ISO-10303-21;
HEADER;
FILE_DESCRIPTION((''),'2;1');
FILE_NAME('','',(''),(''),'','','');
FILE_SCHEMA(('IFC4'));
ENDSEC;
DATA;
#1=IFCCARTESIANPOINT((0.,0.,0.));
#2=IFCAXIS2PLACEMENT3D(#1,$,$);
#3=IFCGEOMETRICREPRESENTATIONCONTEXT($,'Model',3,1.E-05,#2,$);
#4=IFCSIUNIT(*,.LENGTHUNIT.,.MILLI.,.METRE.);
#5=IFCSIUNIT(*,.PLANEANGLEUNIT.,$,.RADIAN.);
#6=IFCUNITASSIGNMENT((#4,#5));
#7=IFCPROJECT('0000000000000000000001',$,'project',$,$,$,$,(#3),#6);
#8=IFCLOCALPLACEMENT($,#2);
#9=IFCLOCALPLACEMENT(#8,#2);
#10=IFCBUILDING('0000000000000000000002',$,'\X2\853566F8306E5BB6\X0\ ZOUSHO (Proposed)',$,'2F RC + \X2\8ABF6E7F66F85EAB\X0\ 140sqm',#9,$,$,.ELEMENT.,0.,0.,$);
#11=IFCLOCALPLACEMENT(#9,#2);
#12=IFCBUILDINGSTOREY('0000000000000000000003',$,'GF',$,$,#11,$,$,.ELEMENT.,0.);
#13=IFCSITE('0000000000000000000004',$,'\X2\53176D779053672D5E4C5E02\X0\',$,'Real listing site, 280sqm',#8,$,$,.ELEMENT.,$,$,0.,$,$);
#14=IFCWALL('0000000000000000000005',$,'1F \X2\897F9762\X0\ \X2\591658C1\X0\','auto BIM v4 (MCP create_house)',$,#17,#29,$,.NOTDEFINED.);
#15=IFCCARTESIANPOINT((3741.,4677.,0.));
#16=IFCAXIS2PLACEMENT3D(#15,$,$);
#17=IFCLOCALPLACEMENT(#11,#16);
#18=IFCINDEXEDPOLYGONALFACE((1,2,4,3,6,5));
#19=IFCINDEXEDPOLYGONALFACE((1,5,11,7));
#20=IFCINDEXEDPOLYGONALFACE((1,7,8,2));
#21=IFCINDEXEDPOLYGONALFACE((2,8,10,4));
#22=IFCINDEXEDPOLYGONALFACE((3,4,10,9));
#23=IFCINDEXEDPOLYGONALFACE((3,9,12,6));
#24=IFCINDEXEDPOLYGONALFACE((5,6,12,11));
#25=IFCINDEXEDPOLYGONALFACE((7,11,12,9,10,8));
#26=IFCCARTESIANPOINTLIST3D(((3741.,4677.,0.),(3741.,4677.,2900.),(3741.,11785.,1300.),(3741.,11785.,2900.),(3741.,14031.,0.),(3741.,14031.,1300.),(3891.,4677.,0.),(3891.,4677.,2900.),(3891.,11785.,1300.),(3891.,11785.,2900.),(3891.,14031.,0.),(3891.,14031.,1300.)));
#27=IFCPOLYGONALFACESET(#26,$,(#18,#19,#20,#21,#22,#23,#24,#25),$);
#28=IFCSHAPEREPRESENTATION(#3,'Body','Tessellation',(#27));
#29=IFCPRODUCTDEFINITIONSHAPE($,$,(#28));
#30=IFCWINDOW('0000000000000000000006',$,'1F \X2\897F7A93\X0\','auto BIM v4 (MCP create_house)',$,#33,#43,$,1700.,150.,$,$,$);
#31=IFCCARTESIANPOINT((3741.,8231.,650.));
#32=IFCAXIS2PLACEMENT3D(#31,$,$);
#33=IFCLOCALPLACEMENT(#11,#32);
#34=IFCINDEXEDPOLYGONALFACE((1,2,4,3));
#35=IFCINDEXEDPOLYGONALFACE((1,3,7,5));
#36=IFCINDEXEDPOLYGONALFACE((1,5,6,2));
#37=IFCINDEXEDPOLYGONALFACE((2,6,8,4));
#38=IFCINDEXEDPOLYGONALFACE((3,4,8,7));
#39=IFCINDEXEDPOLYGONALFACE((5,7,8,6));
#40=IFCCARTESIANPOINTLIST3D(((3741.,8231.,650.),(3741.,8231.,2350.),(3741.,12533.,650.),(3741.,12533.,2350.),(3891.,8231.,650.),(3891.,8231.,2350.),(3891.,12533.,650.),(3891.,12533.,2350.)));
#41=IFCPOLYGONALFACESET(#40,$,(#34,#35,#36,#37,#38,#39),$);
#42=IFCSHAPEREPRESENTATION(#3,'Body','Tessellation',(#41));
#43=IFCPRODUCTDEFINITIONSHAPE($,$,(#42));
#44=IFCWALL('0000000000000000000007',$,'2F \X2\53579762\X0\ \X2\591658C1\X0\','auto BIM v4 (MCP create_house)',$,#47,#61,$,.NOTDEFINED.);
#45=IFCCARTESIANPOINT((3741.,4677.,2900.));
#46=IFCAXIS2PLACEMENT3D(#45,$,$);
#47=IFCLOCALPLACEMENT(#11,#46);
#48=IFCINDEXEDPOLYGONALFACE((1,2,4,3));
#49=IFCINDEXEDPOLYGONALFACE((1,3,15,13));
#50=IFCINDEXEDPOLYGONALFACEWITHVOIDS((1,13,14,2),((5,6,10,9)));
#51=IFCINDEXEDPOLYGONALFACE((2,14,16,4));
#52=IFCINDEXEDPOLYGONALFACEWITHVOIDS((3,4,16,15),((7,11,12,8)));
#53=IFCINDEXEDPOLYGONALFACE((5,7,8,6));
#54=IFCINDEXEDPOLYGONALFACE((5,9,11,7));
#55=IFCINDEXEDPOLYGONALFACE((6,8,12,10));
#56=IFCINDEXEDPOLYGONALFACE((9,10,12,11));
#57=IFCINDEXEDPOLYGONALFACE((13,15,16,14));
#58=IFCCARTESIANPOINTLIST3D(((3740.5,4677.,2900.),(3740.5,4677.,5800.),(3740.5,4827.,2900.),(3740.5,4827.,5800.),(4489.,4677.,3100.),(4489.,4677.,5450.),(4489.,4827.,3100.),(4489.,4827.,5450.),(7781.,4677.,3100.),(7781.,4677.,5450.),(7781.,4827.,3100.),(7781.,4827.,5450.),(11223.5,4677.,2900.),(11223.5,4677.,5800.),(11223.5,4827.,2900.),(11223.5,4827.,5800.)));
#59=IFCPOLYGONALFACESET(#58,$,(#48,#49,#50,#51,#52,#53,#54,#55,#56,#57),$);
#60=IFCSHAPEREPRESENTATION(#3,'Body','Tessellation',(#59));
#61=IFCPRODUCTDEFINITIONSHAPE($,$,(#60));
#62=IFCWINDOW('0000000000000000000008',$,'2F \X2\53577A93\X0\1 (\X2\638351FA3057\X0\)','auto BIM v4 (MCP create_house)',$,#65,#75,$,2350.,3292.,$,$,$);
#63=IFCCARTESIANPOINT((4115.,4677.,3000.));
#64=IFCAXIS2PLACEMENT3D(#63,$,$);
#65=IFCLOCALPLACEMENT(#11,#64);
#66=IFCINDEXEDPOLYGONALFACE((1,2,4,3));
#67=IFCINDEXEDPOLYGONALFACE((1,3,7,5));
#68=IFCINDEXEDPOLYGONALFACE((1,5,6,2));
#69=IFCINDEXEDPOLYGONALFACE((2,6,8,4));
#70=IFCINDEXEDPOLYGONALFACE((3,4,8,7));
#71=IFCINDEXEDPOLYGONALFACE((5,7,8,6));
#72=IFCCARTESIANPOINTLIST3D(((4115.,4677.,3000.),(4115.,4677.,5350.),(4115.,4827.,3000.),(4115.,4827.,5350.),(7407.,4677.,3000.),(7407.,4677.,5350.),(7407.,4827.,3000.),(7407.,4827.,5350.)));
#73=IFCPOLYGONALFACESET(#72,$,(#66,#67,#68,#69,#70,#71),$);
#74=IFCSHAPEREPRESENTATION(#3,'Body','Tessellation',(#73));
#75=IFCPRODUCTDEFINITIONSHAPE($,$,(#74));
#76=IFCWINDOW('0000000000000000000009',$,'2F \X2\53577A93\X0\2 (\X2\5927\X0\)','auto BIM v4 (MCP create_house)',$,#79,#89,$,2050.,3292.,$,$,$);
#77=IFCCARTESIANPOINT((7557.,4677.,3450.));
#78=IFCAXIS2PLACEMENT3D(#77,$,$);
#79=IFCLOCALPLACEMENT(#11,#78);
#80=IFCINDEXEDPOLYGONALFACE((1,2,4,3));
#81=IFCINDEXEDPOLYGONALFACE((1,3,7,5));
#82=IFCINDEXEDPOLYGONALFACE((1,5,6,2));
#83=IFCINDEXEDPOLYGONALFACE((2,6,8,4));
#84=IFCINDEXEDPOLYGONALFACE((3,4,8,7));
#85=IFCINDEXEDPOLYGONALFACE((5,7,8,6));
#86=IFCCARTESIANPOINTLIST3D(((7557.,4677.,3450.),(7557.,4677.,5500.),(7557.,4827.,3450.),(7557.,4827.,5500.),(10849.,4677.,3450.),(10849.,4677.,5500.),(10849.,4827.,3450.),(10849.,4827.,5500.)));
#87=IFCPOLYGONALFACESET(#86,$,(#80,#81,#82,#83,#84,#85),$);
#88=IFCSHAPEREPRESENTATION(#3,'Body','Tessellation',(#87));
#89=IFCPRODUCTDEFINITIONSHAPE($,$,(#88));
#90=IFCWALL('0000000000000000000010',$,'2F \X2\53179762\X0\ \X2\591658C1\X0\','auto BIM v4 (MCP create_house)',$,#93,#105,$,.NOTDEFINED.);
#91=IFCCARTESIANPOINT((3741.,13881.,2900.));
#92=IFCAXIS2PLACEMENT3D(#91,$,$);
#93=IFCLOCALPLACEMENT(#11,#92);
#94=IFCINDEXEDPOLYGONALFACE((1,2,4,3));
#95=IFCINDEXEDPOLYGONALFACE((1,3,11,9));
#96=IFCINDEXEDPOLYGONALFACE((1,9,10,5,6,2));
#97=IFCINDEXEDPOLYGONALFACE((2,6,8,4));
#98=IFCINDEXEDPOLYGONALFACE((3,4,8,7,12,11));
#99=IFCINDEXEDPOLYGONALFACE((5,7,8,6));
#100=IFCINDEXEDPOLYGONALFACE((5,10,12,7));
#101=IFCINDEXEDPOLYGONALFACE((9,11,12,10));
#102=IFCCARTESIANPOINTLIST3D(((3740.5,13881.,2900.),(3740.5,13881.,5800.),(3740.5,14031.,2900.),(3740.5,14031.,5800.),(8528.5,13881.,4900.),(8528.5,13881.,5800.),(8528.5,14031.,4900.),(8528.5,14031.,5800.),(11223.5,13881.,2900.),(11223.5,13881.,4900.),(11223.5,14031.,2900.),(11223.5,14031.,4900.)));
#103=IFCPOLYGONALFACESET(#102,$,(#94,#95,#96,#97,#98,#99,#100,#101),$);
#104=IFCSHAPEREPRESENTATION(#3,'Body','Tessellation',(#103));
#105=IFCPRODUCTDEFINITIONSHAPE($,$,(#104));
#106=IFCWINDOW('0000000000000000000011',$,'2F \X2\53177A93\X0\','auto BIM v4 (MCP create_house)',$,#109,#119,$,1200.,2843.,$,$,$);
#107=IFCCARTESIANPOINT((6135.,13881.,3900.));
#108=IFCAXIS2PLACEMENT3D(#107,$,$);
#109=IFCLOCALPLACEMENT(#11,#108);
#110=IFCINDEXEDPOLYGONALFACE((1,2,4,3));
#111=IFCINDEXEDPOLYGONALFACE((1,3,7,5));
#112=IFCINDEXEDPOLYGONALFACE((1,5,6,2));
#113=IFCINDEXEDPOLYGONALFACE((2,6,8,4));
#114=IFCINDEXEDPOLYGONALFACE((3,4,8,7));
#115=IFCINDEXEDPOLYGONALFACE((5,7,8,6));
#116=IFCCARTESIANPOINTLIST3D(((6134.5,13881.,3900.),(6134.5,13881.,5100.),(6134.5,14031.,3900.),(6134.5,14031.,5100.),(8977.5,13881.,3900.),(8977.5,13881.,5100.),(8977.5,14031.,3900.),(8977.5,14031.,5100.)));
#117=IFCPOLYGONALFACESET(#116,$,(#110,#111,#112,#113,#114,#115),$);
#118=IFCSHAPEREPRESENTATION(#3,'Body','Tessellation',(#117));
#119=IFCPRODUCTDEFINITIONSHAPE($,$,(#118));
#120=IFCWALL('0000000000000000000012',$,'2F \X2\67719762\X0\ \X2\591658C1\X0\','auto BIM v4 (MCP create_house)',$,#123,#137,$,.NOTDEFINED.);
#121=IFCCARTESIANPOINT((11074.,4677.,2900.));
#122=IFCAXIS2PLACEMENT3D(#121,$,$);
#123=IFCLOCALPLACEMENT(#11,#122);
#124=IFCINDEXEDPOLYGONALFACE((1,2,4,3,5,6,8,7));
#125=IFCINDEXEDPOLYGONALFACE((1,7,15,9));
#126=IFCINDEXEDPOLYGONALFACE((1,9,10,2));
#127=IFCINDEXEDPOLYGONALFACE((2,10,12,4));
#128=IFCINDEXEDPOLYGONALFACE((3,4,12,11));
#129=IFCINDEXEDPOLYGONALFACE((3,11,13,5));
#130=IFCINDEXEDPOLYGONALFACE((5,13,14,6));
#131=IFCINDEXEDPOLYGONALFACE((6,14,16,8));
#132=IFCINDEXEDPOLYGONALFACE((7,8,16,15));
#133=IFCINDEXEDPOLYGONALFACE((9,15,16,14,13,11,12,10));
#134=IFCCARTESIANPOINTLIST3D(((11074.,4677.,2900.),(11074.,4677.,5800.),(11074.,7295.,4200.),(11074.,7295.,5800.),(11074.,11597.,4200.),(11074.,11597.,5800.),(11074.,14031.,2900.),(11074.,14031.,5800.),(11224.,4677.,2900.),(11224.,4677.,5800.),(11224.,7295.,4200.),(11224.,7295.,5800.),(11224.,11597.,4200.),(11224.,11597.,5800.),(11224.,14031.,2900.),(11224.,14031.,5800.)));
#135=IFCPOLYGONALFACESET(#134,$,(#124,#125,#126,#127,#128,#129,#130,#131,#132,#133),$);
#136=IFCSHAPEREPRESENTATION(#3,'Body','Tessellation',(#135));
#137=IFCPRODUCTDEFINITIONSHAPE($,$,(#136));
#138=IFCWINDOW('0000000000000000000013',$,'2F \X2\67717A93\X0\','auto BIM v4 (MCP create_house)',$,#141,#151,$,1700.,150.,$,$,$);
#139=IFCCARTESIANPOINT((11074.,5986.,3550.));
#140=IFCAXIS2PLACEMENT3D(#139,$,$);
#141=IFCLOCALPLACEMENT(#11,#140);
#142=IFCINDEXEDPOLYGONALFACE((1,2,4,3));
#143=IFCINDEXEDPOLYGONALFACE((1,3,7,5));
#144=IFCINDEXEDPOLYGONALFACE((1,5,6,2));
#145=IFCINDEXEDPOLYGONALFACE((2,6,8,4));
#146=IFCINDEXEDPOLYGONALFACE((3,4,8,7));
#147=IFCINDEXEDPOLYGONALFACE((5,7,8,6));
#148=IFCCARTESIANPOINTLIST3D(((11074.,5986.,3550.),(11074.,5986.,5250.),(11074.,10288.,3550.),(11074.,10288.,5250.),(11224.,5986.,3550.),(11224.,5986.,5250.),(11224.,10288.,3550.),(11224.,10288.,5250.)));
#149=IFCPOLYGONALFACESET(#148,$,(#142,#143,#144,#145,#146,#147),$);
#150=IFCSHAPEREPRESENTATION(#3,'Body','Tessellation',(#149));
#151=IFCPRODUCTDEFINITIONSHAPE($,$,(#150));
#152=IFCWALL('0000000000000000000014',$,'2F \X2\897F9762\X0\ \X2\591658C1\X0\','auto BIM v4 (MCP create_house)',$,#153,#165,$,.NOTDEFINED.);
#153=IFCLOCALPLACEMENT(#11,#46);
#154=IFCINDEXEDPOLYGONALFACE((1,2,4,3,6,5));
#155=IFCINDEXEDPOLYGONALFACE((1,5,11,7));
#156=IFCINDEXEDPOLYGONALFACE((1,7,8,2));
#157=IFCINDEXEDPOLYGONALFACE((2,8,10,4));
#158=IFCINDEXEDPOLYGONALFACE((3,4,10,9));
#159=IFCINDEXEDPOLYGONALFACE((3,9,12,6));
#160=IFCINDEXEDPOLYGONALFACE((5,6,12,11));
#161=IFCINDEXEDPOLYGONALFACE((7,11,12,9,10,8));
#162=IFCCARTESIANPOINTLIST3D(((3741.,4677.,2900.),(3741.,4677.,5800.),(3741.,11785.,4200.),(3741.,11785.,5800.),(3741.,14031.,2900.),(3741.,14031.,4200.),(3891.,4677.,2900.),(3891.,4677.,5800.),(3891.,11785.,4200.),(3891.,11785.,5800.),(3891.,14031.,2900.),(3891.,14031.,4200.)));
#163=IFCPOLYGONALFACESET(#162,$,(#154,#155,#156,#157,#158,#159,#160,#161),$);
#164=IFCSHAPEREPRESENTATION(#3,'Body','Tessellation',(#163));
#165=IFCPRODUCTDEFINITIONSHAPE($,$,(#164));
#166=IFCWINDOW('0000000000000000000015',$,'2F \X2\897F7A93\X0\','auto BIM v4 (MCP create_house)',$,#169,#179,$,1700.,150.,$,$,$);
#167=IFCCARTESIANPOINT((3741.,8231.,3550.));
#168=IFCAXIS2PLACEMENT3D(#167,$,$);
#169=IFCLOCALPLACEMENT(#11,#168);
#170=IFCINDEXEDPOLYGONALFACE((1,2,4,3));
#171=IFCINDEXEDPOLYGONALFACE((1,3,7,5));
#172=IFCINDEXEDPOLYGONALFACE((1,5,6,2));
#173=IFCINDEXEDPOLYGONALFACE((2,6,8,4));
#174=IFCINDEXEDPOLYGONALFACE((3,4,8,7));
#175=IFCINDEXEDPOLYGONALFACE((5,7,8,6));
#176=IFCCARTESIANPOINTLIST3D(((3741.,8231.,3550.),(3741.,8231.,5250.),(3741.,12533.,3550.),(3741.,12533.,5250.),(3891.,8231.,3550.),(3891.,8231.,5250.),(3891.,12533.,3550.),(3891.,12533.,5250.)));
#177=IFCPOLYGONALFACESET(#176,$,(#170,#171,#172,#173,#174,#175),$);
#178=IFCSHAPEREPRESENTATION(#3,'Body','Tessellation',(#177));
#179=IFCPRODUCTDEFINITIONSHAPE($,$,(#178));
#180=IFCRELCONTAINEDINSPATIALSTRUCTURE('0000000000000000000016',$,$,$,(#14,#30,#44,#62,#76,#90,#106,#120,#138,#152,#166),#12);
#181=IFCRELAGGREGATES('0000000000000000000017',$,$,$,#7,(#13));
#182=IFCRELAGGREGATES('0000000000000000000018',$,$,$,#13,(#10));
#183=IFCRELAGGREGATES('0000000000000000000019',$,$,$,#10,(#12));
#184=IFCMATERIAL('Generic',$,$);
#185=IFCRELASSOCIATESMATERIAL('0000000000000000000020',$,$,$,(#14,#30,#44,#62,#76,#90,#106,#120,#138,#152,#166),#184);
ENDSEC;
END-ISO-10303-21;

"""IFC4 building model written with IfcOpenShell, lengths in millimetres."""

from ifc_helpers import new_model, si_unit, frame, frame_2d, origin, place, context, project, spatial, rectangle, extrude, material, element, fill, save


model = new_model("IFC4")

# Units and contexts
model_context = context("Model", 3, precision=1e-05, world=origin())
ifc_project = project(units=[si_unit("LENGTHUNIT", "METRE", prefix="MILLI"), si_unit("PLANEANGLEUNIT", "RADIAN")], contexts=[model_context])

# Site, building, storey
site_placement = place(None, origin())
site = spatial("IfcSite", under=ifc_project, at=site_placement, Name="北海道札幌市", ObjectType="Real listing site, 280sqm", CompositionType="ELEMENT", RefElevation=0.0)
building_placement = place(site_placement, origin())
building = spatial("IfcBuilding", under=site, at=building_placement, Name="蔵書の家 ZOUSHO (Proposed)", ObjectType="2F RC + 調湿書庫 140sqm", CompositionType="ELEMENT", ElevationOfRefHeight=0.0, ElevationOfTerrain=0.0)
storey_placement = place(building_placement, origin())
storey = spatial("IfcBuildingStorey", under=building, at=storey_placement, Name="GF", CompositionType="ELEMENT", Elevation=0.0)

# Shared definitions
ifc_material = material(Name="Generic")

# Wall, opening, window
wall_1_placement = place(storey_placement, frame((3741.0, 4677.0, 0.0)))
wall_1 = element("IfcWall", 1, at=wall_1_placement, inside=storey, material=ifc_material, Name="1F 西面 外壁", Description="auto BIM v4 (MCP create_house)", PredefinedType="NOTDEFINED", context=model_context, shape_type="SweptSolid", body=[
    extrude(rectangle(XDim=150.0, YDim=9354.0, at=frame_2d((75.0, 4677.0))), frame((3741.0, 4677.0, 0.0)), (0.0, 0.0, 1.0), 2900.0),
])
opening_1_placement = place(storey_placement, frame((3741.0, 8231.0, 650.0)))
opening_1 = element("IfcOpeningElement", 2, at=opening_1_placement, cuts=wall_1, PredefinedType="NOTDEFINED", context=model_context, shape_type="SweptSolid", body=[
    extrude(rectangle(XDim=150.0, YDim=4302.0, at=frame_2d((75.0, 2151.0))), frame((3741.0, 8231.0, 650.0)), (0.0, 0.0, 1.0), 1700.0),
])
window_1_placement = place(storey_placement, frame((3741.0, 8231.0, 650.0)))
window_1 = element("IfcWindow", 3, at=window_1_placement, inside=storey, material=ifc_material, Name="1F 西窓", Description="auto BIM v4 (MCP create_house)", OverallHeight=1700.0, OverallWidth=150.0, context=model_context, shape_type="SweptSolid", body=[
    extrude(rectangle(XDim=150.0, YDim=4302.0, at=frame_2d((75.0, 2151.0))), frame((3741.0, 8231.0, 650.0)), (0.0, 0.0, 1.0), 1700.0),
])
fill(opening_1, window_1)

# Wall, openings, windows
wall_2_placement = place(storey_placement, frame((3741.0, 4677.0, 2900.0)))
wall_2 = element("IfcWall", 4, at=wall_2_placement, inside=storey, material=ifc_material, Name="2F 南面 外壁", Description="auto BIM v4 (MCP create_house)", PredefinedType="NOTDEFINED", context=model_context, shape_type="SweptSolid", body=[
    extrude(rectangle(XDim=7483.0, YDim=150.0, at=frame_2d((3741.0, 75.0))), frame((3741.0, 4677.0, 2900.0)), (0.0, 0.0, 1.0), 2900.0),
])
opening_2_placement = place(storey_placement, frame((4115.0, 4677.0, 3000.0)))
opening_2 = element("IfcOpeningElement", 5, at=opening_2_placement, cuts=wall_2, PredefinedType="NOTDEFINED", context=model_context, shape_type="SweptSolid", body=[
    extrude(rectangle(XDim=3292.0, YDim=150.0, at=frame_2d((1646.0, 75.0))), frame((4115.0, 4677.0, 3000.0)), (0.0, 0.0, 1.0), 2350.0),
])
opening_3_placement = place(storey_placement, frame((7557.0, 4677.0, 3450.0)))
opening_3 = element("IfcOpeningElement", 6, at=opening_3_placement, cuts=wall_2, PredefinedType="NOTDEFINED", context=model_context, shape_type="SweptSolid", body=[
    extrude(rectangle(XDim=3292.0, YDim=150.0, at=frame_2d((1646.0, 75.0))), frame((7557.0, 4677.0, 3450.0)), (0.0, 0.0, 1.0), 2050.0),
])
window_2_placement = place(storey_placement, frame((4115.0, 4677.0, 3000.0)))
window_2 = element("IfcWindow", 7, at=window_2_placement, inside=storey, material=ifc_material, Name="2F 南窓1 (掃出し)", Description="auto BIM v4 (MCP create_house)", OverallHeight=2350.0, OverallWidth=3292.0, context=model_context, shape_type="SweptSolid", body=[
    extrude(rectangle(XDim=3292.0, YDim=150.0, at=frame_2d((1646.0, 75.0))), frame((4115.0, 4677.0, 3000.0)), (0.0, 0.0, 1.0), 2350.0),
])
fill(opening_2, window_2)
window_3_placement = place(storey_placement, frame((7557.0, 4677.0, 3450.0)))
window_3 = element("IfcWindow", 8, at=window_3_placement, inside=storey, material=ifc_material, Name="2F 南窓2 (大)", Description="auto BIM v4 (MCP create_house)", OverallHeight=2050.0, OverallWidth=3292.0, context=model_context, shape_type="SweptSolid", body=[
    extrude(rectangle(XDim=3292.0, YDim=150.0, at=frame_2d((1646.0, 75.0))), frame((7557.0, 4677.0, 3450.0)), (0.0, 0.0, 1.0), 2050.0),
])
fill(opening_3, window_3)

# Walls, openings, windows
wall_3_placement = place(storey_placement, frame((3741.0, 13881.0, 2900.0)))
wall_3 = element("IfcWall", 9, at=wall_3_placement, inside=storey, material=ifc_material, Name="2F 北面 外壁", Description="auto BIM v4 (MCP create_house)", PredefinedType="NOTDEFINED", context=model_context, shape_type="SweptSolid", body=[
    extrude(rectangle(XDim=7483.0, YDim=150.0, at=frame_2d((3741.0, 75.0))), frame((3741.0, 13881.0, 2900.0)), (0.0, 0.0, 1.0), 2900.0),
])
opening_4_placement = place(storey_placement, frame((6135.0, 13881.0, 3900.0)))
opening_4 = element("IfcOpeningElement", 10, at=opening_4_placement, cuts=wall_3, PredefinedType="NOTDEFINED", context=model_context, shape_type="SweptSolid", body=[
    extrude(rectangle(XDim=2843.0, YDim=150.0, at=frame_2d((1421.0, 75.0))), frame((6135.0, 13881.0, 3900.0)), (0.0, 0.0, 1.0), 1200.0),
])
window_4_placement = place(storey_placement, frame((6135.0, 13881.0, 3900.0)))
window_4 = element("IfcWindow", 11, at=window_4_placement, inside=storey, material=ifc_material, Name="2F 北窓", Description="auto BIM v4 (MCP create_house)", OverallHeight=1200.0, OverallWidth=2843.0, context=model_context, shape_type="SweptSolid", body=[
    extrude(rectangle(XDim=2843.0, YDim=150.0, at=frame_2d((1421.0, 75.0))), frame((6135.0, 13881.0, 3900.0)), (0.0, 0.0, 1.0), 1200.0),
])
fill(opening_4, window_4)
wall_4_placement = place(storey_placement, frame((11074.0, 4677.0, 2900.0)))
wall_4 = element("IfcWall", 12, at=wall_4_placement, inside=storey, material=ifc_material, Name="2F 東面 外壁", Description="auto BIM v4 (MCP create_house)", PredefinedType="NOTDEFINED", context=model_context, shape_type="SweptSolid", body=[
    extrude(rectangle(XDim=150.0, YDim=9354.0, at=frame_2d((75.0, 4677.0))), frame((11074.0, 4677.0, 2900.0)), (0.0, 0.0, 1.0), 2900.0),
])
opening_5_placement = place(storey_placement, frame((11074.0, 5986.0, 3550.0)))
opening_5 = element("IfcOpeningElement", 13, at=opening_5_placement, cuts=wall_4, PredefinedType="NOTDEFINED", context=model_context, shape_type="SweptSolid", body=[
    extrude(rectangle(XDim=150.0, YDim=4302.0, at=frame_2d((75.0, 2151.0))), frame((11074.0, 5986.0, 3550.0)), (0.0, 0.0, 1.0), 1700.0),
])
window_5_placement = place(storey_placement, frame((11074.0, 5986.0, 3550.0)))
window_5 = element("IfcWindow", 14, at=window_5_placement, inside=storey, material=ifc_material, Name="2F 東窓", Description="auto BIM v4 (MCP create_house)", OverallHeight=1700.0, OverallWidth=150.0, context=model_context, shape_type="SweptSolid", body=[
    extrude(rectangle(XDim=150.0, YDim=4302.0, at=frame_2d((75.0, 2151.0))), frame((11074.0, 5986.0, 3550.0)), (0.0, 0.0, 1.0), 1700.0),
])
fill(opening_5, window_5)
wall_5_placement = place(storey_placement, frame((3741.0, 4677.0, 2900.0)))
wall_5 = element("IfcWall", 15, at=wall_5_placement, inside=storey, material=ifc_material, Name="2F 西面 外壁", Description="auto BIM v4 (MCP create_house)", PredefinedType="NOTDEFINED", context=model_context, shape_type="SweptSolid", body=[
    extrude(rectangle(XDim=150.0, YDim=9354.0, at=frame_2d((75.0, 4677.0))), frame((3741.0, 4677.0, 2900.0)), (0.0, 0.0, 1.0), 2900.0),
])
opening_6_placement = place(storey_placement, frame((3741.0, 8231.0, 3550.0)))
opening_6 = element("IfcOpeningElement", 16, at=opening_6_placement, cuts=wall_5, PredefinedType="NOTDEFINED", context=model_context, shape_type="SweptSolid", body=[
    extrude(rectangle(XDim=150.0, YDim=4302.0, at=frame_2d((75.0, 2151.0))), frame((3741.0, 8231.0, 3550.0)), (0.0, 0.0, 1.0), 1700.0),
])
window_6_placement = place(storey_placement, frame((3741.0, 8231.0, 3550.0)))
window_6 = element("IfcWindow", 17, at=window_6_placement, inside=storey, material=ifc_material, Name="2F 西窓", Description="auto BIM v4 (MCP create_house)", OverallHeight=1700.0, OverallWidth=150.0, context=model_context, shape_type="SweptSolid", body=[
    extrude(rectangle(XDim=150.0, YDim=4302.0, at=frame_2d((75.0, 2151.0))), frame((3741.0, 8231.0, 3550.0)), (0.0, 0.0, 1.0), 1700.0),
])
fill(opening_6, window_6)

save(model, "model.ifc")
